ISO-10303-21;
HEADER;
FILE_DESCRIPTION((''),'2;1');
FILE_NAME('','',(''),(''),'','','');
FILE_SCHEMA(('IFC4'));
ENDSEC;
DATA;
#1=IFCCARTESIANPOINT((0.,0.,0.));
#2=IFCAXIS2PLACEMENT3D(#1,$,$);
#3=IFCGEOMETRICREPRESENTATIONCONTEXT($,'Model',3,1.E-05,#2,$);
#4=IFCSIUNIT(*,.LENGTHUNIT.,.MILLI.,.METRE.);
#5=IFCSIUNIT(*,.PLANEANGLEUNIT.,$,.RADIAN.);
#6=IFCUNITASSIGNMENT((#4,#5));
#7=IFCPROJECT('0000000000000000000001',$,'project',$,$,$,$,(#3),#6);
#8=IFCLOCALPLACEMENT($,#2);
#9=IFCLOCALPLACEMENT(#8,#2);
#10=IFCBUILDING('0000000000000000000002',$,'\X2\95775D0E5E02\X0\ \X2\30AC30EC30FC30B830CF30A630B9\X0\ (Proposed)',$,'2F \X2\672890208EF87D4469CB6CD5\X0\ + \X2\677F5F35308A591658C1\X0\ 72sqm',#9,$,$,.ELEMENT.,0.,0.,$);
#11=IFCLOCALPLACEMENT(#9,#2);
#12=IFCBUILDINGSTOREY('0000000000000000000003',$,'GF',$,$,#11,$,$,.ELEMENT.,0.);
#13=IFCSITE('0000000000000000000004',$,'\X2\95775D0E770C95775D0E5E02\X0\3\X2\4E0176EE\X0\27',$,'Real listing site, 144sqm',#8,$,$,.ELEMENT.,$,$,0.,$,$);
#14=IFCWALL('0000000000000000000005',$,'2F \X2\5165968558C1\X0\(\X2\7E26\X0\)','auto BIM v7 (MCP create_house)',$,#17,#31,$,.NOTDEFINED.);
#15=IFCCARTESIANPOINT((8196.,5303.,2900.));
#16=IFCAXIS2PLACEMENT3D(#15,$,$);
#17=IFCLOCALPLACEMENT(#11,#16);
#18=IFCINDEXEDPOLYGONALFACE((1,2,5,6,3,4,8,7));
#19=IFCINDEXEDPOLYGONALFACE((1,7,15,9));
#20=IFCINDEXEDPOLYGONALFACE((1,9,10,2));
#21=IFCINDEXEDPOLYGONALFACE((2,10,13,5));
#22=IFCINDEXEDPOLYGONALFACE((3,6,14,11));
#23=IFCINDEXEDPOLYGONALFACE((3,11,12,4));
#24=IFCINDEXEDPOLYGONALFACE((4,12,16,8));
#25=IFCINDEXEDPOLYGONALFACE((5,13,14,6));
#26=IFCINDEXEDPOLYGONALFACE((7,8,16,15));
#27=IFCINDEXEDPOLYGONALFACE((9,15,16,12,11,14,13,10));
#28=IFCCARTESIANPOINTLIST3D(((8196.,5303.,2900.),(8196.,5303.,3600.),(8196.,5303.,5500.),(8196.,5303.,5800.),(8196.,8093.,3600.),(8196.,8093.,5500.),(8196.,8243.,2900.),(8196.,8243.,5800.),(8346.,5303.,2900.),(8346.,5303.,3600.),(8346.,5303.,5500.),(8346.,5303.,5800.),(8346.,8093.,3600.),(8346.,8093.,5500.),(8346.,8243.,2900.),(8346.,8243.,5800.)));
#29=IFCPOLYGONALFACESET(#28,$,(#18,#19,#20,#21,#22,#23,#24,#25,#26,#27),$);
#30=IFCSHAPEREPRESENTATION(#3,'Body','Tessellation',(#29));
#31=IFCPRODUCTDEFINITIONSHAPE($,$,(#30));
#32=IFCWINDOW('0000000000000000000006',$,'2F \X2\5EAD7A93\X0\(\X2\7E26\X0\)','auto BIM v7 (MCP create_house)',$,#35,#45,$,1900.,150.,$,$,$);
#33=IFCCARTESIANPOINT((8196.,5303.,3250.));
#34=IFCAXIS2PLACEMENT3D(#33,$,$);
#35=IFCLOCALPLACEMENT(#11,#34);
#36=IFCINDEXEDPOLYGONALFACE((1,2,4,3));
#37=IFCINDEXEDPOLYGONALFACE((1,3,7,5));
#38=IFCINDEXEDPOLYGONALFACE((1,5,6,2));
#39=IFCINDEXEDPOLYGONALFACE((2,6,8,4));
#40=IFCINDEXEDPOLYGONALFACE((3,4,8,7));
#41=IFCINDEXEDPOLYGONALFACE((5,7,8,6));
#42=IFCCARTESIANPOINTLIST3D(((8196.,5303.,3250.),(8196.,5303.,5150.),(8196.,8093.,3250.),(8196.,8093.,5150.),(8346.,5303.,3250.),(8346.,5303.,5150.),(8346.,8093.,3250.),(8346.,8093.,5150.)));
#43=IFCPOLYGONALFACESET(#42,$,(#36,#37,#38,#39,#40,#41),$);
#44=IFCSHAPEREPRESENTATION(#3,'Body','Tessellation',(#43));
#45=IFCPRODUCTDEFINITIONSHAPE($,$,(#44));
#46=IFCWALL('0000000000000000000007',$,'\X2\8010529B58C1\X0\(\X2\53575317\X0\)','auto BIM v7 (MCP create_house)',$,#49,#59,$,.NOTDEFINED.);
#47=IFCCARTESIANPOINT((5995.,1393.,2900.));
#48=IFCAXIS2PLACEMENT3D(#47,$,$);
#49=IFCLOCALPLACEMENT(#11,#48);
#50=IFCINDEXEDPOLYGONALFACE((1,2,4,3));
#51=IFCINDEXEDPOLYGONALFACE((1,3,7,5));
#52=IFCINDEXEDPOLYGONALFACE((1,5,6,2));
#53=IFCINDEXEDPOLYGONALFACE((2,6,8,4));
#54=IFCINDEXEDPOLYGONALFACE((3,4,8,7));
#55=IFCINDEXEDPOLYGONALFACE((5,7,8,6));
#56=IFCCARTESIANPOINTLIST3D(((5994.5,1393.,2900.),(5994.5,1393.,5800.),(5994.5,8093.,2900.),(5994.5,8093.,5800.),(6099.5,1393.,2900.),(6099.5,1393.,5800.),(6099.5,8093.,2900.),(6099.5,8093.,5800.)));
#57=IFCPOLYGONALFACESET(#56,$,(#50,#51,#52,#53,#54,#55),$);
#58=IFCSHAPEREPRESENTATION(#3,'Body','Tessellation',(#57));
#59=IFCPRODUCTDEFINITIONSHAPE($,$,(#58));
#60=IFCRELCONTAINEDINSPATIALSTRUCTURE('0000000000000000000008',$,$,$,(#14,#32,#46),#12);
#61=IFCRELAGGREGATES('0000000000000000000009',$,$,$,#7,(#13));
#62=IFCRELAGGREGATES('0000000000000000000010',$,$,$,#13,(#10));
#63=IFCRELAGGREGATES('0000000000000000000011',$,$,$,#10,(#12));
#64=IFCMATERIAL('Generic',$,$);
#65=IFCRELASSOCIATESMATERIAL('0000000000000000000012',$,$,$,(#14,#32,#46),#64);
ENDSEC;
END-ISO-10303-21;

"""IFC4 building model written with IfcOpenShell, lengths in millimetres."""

from ifc_helpers import new_model, si_unit, frame, frame_2d, origin, place, context, project, spatial, rectangle, extrude, material, element, fill, save


model = new_model("IFC4")

# Units and contexts
model_context = context("Model", 3, precision=1e-05, world=origin())
ifc_project = project(units=[si_unit("LENGTHUNIT", "METRE", prefix="MILLI"), si_unit("PLANEANGLEUNIT", "RADIAN")], contexts=[model_context])

# Site, building, storey
site_placement = place(None, origin())
site = spatial("IfcSite", under=ifc_project, at=site_placement, Name="長崎県長崎市3丁目27", ObjectType="Real listing site, 144sqm", CompositionType="ELEMENT", RefElevation=0.0)
building_placement = place(site_placement, origin())
building = spatial("IfcBuilding", under=site, at=building_placement, Name="長崎市 ガレージハウス (Proposed)", ObjectType="2F 木造軸組構法 + 板張り外壁 72sqm", CompositionType="ELEMENT", ElevationOfRefHeight=0.0, ElevationOfTerrain=0.0)
storey_placement = place(building_placement, origin())
storey = spatial("IfcBuildingStorey", under=building, at=storey_placement, Name="GF", CompositionType="ELEMENT", Elevation=0.0)

# Shared definitions
ifc_material = material(Name="Generic")

# Wall, opening, window
wall_1_placement = place(storey_placement, frame((8196.0, 5303.0, 2900.0)))
wall_1 = element("IfcWall", 1, at=wall_1_placement, inside=storey, material=ifc_material, Name="2F 入隅壁(縦)", Description="auto BIM v7 (MCP create_house)", PredefinedType="NOTDEFINED", context=model_context, shape_type="SweptSolid", body=[
    extrude(rectangle(XDim=150.0, YDim=2940.0, at=frame_2d((75.0, 1470.0))), frame((8196.0, 5303.0, 2900.0)), (0.0, 0.0, 1.0), 2900.0),
])
opening_1_placement = place(storey_placement, frame((8196.0, 5303.0, 3250.0)))
opening_1 = element("IfcOpeningElement", 2, at=opening_1_placement, cuts=wall_1, PredefinedType="NOTDEFINED", context=model_context, shape_type="SweptSolid", body=[
    extrude(rectangle(XDim=150.0, YDim=2790.0, at=frame_2d((75.0, 1395.0))), frame((8196.0, 5303.0, 3250.0)), (0.0, 0.0, 1.0), 1900.0),
])
window_1_placement = place(storey_placement, frame((8196.0, 5303.0, 3250.0)))
window_1 = element("IfcWindow", 3, at=window_1_placement, inside=storey, material=ifc_material, Name="2F 庭窓(縦)", Description="auto BIM v7 (MCP create_house)", OverallHeight=1900.0, OverallWidth=150.0, context=model_context, shape_type="SweptSolid", body=[
    extrude(rectangle(XDim=150.0, YDim=2790.0, at=frame_2d((75.0, 1395.0))), frame((8196.0, 5303.0, 3250.0)), (0.0, 0.0, 1.0), 1900.0),
])
fill(opening_1, window_1)

# Wall
wall_2_placement = place(storey_placement, frame((5995.0, 1393.0, 2900.0)))
element("IfcWall", 4, at=wall_2_placement, inside=storey, material=ifc_material, Name="耐力壁(南北)", Description="auto BIM v7 (MCP create_house)", PredefinedType="NOTDEFINED", context=model_context, shape_type="SweptSolid", body=[
    extrude(rectangle(XDim=105.0, YDim=6700.0, at=frame_2d((52.0, 3350.0))), frame((5995.0, 1393.0, 2900.0)), (0.0, 0.0, 1.0), 2900.0),
])

save(model, "model.ifc")
